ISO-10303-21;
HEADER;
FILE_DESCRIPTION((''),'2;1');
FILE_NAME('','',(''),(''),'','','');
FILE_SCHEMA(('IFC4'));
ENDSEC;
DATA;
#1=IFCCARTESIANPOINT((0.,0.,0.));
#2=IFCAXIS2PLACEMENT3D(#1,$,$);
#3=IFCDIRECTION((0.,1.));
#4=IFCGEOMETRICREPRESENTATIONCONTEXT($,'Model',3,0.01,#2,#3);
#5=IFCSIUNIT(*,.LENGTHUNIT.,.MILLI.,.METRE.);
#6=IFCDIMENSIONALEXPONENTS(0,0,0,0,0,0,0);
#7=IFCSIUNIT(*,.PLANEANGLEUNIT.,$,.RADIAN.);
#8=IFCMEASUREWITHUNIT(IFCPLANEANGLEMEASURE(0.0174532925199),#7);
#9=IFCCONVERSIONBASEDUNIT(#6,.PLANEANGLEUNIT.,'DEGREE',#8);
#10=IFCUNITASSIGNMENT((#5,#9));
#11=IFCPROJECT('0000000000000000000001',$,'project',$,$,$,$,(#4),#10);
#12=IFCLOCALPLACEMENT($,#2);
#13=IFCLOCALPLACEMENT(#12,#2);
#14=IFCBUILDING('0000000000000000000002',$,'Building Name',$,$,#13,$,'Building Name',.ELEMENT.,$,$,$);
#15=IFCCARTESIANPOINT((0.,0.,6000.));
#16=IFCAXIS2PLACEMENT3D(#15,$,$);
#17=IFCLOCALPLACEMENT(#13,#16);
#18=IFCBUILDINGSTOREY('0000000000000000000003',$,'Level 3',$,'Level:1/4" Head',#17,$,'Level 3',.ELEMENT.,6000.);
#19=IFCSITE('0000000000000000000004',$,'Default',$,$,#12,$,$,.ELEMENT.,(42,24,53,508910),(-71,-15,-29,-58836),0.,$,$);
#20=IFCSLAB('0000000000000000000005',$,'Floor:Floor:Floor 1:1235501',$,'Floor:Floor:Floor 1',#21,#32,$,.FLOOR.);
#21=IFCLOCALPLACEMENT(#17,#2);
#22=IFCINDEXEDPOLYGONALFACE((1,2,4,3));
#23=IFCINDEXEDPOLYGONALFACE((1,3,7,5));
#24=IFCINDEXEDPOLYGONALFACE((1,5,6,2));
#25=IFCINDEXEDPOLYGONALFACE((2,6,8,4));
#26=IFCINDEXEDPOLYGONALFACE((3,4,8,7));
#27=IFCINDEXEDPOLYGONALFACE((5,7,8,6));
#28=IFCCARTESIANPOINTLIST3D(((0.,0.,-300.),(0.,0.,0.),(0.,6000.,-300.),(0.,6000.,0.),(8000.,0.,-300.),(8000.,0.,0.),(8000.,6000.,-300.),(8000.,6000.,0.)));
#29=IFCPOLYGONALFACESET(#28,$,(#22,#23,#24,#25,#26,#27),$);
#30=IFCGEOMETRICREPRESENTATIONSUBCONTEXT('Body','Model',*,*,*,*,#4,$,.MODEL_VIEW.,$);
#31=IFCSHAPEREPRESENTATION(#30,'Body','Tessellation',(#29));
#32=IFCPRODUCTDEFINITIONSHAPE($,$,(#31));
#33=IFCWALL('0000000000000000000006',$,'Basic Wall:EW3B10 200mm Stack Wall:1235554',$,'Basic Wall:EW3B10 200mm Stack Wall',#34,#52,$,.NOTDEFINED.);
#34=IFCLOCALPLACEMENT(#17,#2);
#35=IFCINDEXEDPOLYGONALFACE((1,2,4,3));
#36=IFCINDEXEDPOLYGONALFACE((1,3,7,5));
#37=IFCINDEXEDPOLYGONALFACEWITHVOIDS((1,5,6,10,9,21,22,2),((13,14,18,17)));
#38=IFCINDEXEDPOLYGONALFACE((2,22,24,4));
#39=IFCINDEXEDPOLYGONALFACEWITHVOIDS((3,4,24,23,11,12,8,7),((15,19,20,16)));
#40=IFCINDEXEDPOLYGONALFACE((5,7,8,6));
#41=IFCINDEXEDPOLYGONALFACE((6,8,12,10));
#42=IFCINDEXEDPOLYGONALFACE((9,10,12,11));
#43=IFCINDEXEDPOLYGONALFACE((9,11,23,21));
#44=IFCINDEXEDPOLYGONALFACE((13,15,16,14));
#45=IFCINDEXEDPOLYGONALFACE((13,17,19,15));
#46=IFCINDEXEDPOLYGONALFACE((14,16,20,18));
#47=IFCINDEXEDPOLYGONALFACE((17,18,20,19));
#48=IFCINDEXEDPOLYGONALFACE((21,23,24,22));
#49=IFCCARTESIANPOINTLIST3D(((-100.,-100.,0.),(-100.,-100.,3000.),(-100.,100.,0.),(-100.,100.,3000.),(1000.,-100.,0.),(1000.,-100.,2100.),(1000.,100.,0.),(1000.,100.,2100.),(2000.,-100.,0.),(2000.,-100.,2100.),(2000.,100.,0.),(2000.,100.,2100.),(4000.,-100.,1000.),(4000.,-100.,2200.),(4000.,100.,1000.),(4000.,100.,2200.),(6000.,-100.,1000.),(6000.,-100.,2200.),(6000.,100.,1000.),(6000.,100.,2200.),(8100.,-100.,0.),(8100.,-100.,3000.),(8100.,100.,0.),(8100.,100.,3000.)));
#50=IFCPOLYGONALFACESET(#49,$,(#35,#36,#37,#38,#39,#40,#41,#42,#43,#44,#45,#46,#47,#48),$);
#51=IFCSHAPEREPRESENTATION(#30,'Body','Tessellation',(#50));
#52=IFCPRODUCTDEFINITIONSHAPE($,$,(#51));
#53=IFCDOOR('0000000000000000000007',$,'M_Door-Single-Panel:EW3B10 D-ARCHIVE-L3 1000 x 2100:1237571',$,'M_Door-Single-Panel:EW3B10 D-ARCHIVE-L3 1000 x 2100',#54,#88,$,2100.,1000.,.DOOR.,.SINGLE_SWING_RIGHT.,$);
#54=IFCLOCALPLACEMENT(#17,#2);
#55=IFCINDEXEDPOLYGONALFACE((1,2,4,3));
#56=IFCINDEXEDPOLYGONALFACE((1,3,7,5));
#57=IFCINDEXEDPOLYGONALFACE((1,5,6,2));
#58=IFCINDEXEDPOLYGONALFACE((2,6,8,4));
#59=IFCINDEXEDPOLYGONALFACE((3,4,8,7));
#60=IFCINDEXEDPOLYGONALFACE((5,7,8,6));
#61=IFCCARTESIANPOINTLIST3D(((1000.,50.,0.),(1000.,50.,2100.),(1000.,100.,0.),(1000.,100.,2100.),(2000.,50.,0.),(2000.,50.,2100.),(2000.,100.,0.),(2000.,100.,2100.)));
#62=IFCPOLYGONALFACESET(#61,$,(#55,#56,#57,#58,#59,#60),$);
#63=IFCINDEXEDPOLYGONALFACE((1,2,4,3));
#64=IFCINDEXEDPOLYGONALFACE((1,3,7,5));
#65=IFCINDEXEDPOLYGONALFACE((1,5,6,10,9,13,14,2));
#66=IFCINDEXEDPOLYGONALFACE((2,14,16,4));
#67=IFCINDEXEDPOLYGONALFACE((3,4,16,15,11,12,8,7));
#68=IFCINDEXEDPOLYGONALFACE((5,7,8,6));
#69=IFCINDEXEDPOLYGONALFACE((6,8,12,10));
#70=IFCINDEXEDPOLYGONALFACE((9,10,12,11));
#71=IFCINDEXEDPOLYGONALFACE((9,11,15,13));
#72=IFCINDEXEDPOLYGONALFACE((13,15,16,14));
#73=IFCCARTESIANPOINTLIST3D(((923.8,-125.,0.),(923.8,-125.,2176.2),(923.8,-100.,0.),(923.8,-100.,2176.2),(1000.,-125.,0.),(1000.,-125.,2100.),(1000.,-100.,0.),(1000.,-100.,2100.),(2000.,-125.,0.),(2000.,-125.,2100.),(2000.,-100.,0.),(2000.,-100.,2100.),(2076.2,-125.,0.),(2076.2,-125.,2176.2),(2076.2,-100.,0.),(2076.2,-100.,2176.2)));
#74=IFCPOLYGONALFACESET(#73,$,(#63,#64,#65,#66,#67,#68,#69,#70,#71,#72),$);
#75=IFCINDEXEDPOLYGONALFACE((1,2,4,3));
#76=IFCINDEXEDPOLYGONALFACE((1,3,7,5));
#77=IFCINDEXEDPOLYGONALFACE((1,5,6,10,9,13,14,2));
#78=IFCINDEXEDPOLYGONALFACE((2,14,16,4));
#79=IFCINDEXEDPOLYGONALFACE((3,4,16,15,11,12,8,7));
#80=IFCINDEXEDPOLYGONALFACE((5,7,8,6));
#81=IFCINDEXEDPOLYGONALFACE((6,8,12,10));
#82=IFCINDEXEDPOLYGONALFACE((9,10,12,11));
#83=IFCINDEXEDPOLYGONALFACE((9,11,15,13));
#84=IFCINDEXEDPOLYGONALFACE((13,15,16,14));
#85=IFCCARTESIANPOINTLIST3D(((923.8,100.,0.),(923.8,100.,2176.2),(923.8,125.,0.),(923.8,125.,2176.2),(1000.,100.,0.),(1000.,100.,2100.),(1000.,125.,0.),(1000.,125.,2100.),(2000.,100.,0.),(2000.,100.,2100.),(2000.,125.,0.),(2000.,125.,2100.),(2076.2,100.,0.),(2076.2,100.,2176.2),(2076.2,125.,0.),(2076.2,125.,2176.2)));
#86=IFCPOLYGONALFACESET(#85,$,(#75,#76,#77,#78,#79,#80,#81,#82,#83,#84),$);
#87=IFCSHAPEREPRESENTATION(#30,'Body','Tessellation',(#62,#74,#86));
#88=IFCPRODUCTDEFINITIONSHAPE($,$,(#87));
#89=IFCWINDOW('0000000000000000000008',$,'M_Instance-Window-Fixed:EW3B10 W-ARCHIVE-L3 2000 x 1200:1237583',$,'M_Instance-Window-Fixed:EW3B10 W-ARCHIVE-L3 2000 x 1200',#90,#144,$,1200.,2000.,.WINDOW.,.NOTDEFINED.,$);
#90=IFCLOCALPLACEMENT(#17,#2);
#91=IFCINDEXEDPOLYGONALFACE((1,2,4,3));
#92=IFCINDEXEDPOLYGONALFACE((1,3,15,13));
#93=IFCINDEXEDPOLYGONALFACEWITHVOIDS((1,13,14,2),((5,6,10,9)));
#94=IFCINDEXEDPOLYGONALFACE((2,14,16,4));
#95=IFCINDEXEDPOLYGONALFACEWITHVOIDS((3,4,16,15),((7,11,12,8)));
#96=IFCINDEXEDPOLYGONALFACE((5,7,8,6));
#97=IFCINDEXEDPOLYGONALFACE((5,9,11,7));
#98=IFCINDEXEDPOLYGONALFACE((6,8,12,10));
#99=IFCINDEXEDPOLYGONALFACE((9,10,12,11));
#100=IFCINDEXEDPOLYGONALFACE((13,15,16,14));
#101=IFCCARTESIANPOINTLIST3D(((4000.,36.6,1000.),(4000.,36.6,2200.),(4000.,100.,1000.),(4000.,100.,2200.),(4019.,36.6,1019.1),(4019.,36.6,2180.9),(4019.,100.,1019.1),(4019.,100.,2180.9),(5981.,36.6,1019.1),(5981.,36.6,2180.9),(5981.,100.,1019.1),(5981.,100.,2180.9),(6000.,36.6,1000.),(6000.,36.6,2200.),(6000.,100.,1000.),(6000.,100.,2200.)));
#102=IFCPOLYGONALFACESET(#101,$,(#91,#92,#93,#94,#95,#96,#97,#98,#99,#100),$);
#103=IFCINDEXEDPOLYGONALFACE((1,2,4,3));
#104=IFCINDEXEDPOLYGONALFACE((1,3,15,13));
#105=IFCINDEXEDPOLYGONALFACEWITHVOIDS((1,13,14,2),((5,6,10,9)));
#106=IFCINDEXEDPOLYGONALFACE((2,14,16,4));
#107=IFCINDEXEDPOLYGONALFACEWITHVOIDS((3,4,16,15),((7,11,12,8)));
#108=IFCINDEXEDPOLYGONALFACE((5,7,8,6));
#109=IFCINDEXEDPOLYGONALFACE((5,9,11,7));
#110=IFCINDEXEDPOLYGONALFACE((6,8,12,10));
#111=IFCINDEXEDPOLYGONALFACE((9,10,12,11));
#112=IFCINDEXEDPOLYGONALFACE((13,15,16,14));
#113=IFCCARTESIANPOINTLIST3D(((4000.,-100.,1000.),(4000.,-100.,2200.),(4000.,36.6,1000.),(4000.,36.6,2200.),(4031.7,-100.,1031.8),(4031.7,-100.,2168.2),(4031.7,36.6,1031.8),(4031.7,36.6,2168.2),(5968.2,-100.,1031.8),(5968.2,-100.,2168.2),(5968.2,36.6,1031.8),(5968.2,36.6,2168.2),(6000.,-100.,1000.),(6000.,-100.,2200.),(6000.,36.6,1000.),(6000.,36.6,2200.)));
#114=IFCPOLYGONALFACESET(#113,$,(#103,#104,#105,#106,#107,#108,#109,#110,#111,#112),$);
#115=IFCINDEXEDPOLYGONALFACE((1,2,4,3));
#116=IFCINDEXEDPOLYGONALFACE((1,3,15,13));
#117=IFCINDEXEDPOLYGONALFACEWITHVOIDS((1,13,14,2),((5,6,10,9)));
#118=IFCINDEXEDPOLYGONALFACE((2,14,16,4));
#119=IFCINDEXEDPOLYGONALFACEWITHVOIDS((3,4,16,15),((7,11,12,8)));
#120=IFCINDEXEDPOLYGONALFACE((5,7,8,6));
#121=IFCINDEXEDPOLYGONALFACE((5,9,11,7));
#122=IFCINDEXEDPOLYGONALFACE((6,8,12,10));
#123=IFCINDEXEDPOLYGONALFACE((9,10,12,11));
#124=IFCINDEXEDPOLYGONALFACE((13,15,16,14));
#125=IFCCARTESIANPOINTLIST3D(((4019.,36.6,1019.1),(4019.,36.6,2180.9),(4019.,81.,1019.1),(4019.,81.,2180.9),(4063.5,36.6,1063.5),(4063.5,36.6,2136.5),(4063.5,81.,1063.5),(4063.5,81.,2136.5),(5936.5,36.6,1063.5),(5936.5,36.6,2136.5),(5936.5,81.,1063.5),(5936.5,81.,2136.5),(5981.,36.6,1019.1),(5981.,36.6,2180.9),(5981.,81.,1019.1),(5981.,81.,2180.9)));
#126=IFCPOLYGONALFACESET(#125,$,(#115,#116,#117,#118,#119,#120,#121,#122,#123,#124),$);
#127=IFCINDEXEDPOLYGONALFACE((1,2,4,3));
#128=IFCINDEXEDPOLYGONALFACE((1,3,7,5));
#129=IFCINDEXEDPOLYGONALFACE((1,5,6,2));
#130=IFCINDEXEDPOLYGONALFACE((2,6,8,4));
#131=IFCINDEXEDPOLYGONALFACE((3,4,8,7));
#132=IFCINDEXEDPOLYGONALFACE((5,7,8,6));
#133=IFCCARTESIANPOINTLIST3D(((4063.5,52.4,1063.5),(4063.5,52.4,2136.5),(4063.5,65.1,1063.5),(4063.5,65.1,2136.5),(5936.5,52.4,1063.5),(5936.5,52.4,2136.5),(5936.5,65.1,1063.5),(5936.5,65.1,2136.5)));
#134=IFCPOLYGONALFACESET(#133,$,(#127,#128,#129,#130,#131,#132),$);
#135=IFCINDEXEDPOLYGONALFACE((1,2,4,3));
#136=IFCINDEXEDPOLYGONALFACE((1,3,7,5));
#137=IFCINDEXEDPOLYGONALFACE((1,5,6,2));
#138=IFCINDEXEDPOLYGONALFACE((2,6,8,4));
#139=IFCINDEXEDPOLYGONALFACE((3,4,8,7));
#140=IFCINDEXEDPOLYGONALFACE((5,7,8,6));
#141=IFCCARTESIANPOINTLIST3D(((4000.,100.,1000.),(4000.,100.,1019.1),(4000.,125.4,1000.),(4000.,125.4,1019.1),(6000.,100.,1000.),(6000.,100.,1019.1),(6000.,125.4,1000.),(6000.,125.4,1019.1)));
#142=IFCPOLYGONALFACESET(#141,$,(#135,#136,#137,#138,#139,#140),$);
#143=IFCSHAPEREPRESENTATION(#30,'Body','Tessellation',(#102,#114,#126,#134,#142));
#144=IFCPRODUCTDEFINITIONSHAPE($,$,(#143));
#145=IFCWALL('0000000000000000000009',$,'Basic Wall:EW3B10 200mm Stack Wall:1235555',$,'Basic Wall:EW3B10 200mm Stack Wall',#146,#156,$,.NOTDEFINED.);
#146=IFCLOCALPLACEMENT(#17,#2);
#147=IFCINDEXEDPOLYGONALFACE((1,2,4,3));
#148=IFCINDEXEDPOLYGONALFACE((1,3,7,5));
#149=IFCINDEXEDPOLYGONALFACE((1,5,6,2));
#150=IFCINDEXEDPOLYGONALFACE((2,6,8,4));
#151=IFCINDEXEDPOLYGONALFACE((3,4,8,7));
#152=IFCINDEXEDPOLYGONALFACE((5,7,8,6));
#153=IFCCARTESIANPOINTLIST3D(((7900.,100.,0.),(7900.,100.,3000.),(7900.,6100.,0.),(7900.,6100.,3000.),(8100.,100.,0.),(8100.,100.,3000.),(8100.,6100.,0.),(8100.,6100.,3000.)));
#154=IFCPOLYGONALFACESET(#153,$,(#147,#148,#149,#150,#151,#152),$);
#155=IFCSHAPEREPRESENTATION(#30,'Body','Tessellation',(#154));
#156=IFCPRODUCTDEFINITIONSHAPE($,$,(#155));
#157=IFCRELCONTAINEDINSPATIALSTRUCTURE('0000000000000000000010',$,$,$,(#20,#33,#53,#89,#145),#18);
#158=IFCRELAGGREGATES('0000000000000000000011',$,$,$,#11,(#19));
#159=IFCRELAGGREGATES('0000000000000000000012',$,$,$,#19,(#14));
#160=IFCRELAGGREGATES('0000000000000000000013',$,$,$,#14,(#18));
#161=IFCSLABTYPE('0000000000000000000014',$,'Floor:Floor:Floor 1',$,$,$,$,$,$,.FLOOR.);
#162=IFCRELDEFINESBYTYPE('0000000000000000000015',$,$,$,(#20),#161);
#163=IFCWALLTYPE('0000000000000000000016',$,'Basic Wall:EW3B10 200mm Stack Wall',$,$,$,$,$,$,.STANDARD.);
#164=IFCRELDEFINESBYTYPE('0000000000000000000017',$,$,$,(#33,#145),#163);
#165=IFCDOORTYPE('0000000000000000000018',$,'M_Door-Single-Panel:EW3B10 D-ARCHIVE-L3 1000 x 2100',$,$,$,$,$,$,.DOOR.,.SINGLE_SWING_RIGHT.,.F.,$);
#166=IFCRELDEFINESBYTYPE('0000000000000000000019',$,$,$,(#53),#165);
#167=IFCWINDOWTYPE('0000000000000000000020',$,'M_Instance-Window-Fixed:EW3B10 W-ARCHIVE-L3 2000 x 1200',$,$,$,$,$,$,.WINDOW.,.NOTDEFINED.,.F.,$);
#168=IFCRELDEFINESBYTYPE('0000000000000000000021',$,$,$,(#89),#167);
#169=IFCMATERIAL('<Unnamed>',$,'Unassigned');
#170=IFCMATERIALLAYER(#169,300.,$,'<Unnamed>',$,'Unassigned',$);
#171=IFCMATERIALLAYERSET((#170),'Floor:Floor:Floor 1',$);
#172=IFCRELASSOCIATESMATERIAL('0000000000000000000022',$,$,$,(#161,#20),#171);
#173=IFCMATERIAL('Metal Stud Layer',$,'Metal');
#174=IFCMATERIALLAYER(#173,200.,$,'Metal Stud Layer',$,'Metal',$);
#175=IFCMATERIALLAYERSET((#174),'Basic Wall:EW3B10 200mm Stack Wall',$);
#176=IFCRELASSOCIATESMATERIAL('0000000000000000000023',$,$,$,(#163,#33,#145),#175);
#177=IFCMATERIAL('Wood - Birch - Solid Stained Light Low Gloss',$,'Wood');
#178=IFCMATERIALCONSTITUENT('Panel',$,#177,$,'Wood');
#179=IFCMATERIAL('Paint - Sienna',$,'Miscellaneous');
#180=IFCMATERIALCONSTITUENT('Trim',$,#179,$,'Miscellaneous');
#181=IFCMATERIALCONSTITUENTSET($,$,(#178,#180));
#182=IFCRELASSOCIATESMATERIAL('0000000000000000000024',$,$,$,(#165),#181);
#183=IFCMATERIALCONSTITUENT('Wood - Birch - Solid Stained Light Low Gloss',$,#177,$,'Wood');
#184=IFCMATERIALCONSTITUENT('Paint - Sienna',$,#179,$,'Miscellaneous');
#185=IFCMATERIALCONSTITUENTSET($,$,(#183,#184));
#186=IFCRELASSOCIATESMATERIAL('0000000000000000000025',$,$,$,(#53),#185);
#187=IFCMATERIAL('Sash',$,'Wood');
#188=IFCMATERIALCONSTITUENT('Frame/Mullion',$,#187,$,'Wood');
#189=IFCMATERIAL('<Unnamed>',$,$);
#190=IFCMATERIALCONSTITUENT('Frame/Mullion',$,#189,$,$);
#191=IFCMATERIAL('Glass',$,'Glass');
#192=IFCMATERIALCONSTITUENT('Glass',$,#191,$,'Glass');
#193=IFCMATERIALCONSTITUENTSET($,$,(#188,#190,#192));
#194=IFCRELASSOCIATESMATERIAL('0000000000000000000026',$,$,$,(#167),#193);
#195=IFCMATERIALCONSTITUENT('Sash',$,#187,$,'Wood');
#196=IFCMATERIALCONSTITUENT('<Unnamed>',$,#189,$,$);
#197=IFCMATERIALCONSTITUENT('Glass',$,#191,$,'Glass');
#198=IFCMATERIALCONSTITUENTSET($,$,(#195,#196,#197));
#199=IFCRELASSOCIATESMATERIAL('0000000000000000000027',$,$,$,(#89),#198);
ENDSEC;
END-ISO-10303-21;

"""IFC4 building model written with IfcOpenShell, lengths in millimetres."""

from ifc_helpers import new_model, entity, si_unit, converted_unit, direction, frame, frame_2d, origin, origin_2d_with_axis, place, context, subcontext, project, spatial, polyline, rectangle, outline, extrude, source, transform, mapped, material, layer, layer_set, layer_usage, constituent, constituent_set, type_object, type_shapes, element, fill, save


model = new_model("IFC4")

# Units and contexts
model_context = context("Model", 3, precision=0.01, world=origin(), true_north=direction((0.0, 1.0)))
body_context = subcontext(model_context, "Body", "Model", "MODEL_VIEW")
ifc_project = project(units=[si_unit("LENGTHUNIT", "METRE", prefix="MILLI"), converted_unit("PLANEANGLEUNIT", "DEGREE", entity("IfcPlaneAngleMeasure", 0.0174532925199), si_unit("PLANEANGLEUNIT", "RADIAN"), dimensions=[0, 0, 0, 0, 0, 0, 0])], contexts=[model_context])

# Site, building, storey
site_placement = place(None, origin())
site = spatial("IfcSite", under=ifc_project, at=site_placement, Name="Default", CompositionType="ELEMENT", RefLatitude=(42, 24, 53, 508910), RefLongitude=(-71, -15, -29, -58836), RefElevation=0.0)
building_placement = place(site_placement, origin())
building = spatial("IfcBuilding", under=site, at=building_placement, Name="Building Name", LongName="Building Name", CompositionType="ELEMENT")
storey_placement = place(building_placement, frame((0.0, 0.0, 6000.0)))
storey = spatial("IfcBuildingStorey", under=building, at=storey_placement, Name="Level 3", ObjectType="Level:1/4\" Head", LongName="Level 3", CompositionType="ELEMENT", Elevation=6000.0)

# Slab
ifc_material_1 = material(Name="<Unnamed>", Category="Unassigned")
ifc_layer_1 = layer(ifc_material_1, 300.0, Name="<Unnamed>", Category="Unassigned")
ifc_layer_set_1 = layer_set([ifc_layer_1], Name="Floor:Floor:Floor 1")
ifc_layer_usage_1 = layer_usage(ifc_layer_set_1, "AXIS3", "POSITIVE", 0.0)
slab_type = type_object("IfcSlabType", Name="Floor:Floor:Floor 1", PredefinedType="FLOOR", material=ifc_layer_set_1)
slab_placement = place(storey_placement, origin())
element("IfcSlab", 1, at=slab_placement, inside=storey, type_object=slab_type, material=ifc_layer_usage_1, Name="Floor:Floor:Floor 1:1235501", ObjectType="Floor:Floor:Floor 1", PredefinedType="FLOOR", context=body_context, shape_type="SweptSolid", body=[
    extrude(rectangle(XDim=6000.0, YDim=8000.0, at=origin_2d_with_axis()), frame((4000.0, 3000.0, 0.0), z_axis=(0.0, 0.0, -1.0), x_axis=(0.0, 1.0, 0.0)), (0.0, 0.0, 1.0), 300.0),
])

# Wall, openings, door, window
ifc_material_2 = material(Name="Metal Stud Layer", Category="Metal")
ifc_layer_2 = layer(ifc_material_2, 200.0, Name="Metal Stud Layer", Category="Metal")
ifc_layer_set_2 = layer_set([ifc_layer_2], Name="Basic Wall:EW3B10 200mm Stack Wall")
ifc_layer_usage_2 = layer_usage(ifc_layer_set_2, "AXIS2", "NEGATIVE", 100.0)
wall_type = type_object("IfcWallType", Name="Basic Wall:EW3B10 200mm Stack Wall", PredefinedType="STANDARD", material=ifc_layer_set_2)
wall_1_placement = place(storey_placement, frame((-100.0, 0.0, 0.0)))
wall_1 = element("IfcWall", 2, at=wall_1_placement, inside=storey, type_object=wall_type, material=ifc_layer_usage_2, Name="Basic Wall:EW3B10 200mm Stack Wall:1235554", ObjectType="Basic Wall:EW3B10 200mm Stack Wall", PredefinedType="NOTDEFINED", context=body_context, shape_type="SweptSolid", body=[
    extrude(rectangle(XDim=8200.0, YDim=200.0, at=frame_2d((4100.0, 0.0), x_axis=(1.0, 0.0))), origin(), (0.0, 0.0, 1.0), 3000.0),
])
opening_1_placement = place(wall_1_placement, frame((1100.0, -100.0, 0.0)))
opening_1 = element("IfcOpeningElement", 3, at=opening_1_placement, cuts=wall_1, PredefinedType="OPENING", context=body_context, shape_type="SweptSolid", body=[
    extrude(rectangle(XDim=1000.0, YDim=2100.0, at=frame_2d((1050.0, 500.0), x_axis=(0.0, 1.0))), frame((0.0, 0.0, 0.0), z_axis=(0.0, 1.0, 0.0), x_axis=(0.0, 0.0, 1.0)), (0.0, 0.0, 1.0), 200.0),
])
opening_2_placement = place(wall_1_placement, frame((4100.0, -100.0, 1000.0)))
opening_2 = element("IfcOpeningElement", 4, at=opening_2_placement, cuts=wall_1, PredefinedType="OPENING", context=body_context, shape_type="SweptSolid", body=[
    extrude(rectangle(XDim=1200.0, YDim=2000.0, at=frame_2d((600.0, 1000.0), x_axis=(-1.0, 0.0))), frame((0.0, 0.0, 0.0), z_axis=(0.0, 1.0, 0.0), x_axis=(0.0, 0.0, 1.0)), (0.0, 0.0, 1.0), 200.0),
])
ifc_material_3 = material(Name="Wood - Birch - Solid Stained Light Low Gloss", Category="Wood")
ifc_constituent_1 = constituent(ifc_material_3, Name="Wood - Birch - Solid Stained Light Low Gloss", Category="Wood")
ifc_material_4 = material(Name="Paint - Sienna", Category="Miscellaneous")
ifc_constituent_2 = constituent(ifc_material_4, Name="Paint - Sienna", Category="Miscellaneous")
ifc_constituent_set_1 = constituent_set(constituents=[ifc_constituent_1, ifc_constituent_2])
ifc_constituent_3 = constituent(ifc_material_3, Name="Panel", Category="Wood")
ifc_constituent_4 = constituent(ifc_material_4, Name="Trim", Category="Miscellaneous")
ifc_constituent_set_2 = constituent_set(constituents=[ifc_constituent_3, ifc_constituent_4])
door_type = type_object("IfcDoorType", Name="M_Door-Single-Panel:EW3B10 D-ARCHIVE-L3 1000 x 2100", OperationType="SINGLE_SWING_RIGHT", ParameterTakesPrecedence=False, PredefinedType="DOOR", material=ifc_constituent_set_2)
shared_shape_1 = source(origin(), body_context, "Body", "SweptSolid", [
    extrude(rectangle(XDim=50.0, YDim=1000.0, at=frame_2d((0.0, 0.0), x_axis=(1.0, 0.0))), frame((500.0, 175.0, 0.0), z_axis=(0.0, 0.0, 1.0), x_axis=(0.0, 1.0, 0.0)), (0.0, 0.0, 1.0), 2100.0),
    extrude(outline(polyline([(-1107.2, -576.2), (1069.0, -576.2), (1069.0, -500.0), (-1031.0, -500.0), (-1031.0, 500.0), (1069.0, 500.0), (1069.0, 576.2), (-1107.2, 576.2), (-1107.2, -576.2)])), frame((500.0, -25.0, 1069.0), z_axis=(0.0, 1.0, 0.0), x_axis=(0.0, 0.0, -1.0)), (0.0, 0.0, 1.0), 25.0),
    extrude(outline(polyline([(-576.2, -1107.2), (576.2, -1107.2), (576.2, 1069.0), (500.0, 1069.0), (500.0, -1031.0), (-500.0, -1031.0), (-500.0, 1069.0), (-576.2, 1069.0), (-576.2, -1107.2)])), frame((500.0, 200.0, 1069.0), z_axis=(0.0, 1.0, 0.0), x_axis=(1.0, 0.0, 0.0)), (0.0, 0.0, 1.0), 25.0),
])
type_shapes(door_type, [shared_shape_1])
door_placement = place(opening_1_placement, origin())
door = element("IfcDoor", 5, at=door_placement, inside=storey, type_object=door_type, material=ifc_constituent_set_1, Name="M_Door-Single-Panel:EW3B10 D-ARCHIVE-L3 1000 x 2100:1237571", ObjectType="M_Door-Single-Panel:EW3B10 D-ARCHIVE-L3 1000 x 2100", OperationType="SINGLE_SWING_RIGHT", OverallHeight=2100.0, OverallWidth=1000.0, PredefinedType="DOOR", context=body_context, shape_type="MappedRepresentation", body=[
    mapped(shared_shape_1, transform((0.0, 0.0, 0.0), scale=1.0)),
])
fill(opening_1, door)
ifc_material_5 = material(Name="Sash", Category="Wood")
ifc_constituent_5 = constituent(ifc_material_5, Name="Sash", Category="Wood")
ifc_material_6 = material(Name="<Unnamed>")
ifc_constituent_6 = constituent(ifc_material_6, Name="<Unnamed>")
ifc_material_7 = material(Name="Glass", Category="Glass")
ifc_constituent_7 = constituent(ifc_material_7, Name="Glass", Category="Glass")
ifc_constituent_set_3 = constituent_set(constituents=[ifc_constituent_5, ifc_constituent_6, ifc_constituent_7])
ifc_constituent_8 = constituent(ifc_material_5, Name="Frame/Mullion", Category="Wood")
ifc_constituent_9 = constituent(ifc_material_6, Name="Frame/Mullion")
ifc_constituent_10 = constituent(ifc_material_7, Name="Glass", Category="Glass")
ifc_constituent_set_4 = constituent_set(constituents=[ifc_constituent_8, ifc_constituent_9, ifc_constituent_10])
window_type = type_object("IfcWindowType", Name="M_Instance-Window-Fixed:EW3B10 W-ARCHIVE-L3 2000 x 1200", ParameterTakesPrecedence=False, PartitioningType="NOTDEFINED", PredefinedType="WINDOW", material=ifc_constituent_set_4)
shared_shape_2 = source(origin(), body_context, "Body", "SweptSolid", [
    extrude(outline(polyline([(-600.0, -1000.0), (600.0, -1000.0), (600.0, 1000.0), (-600.0, 1000.0), (-600.0, -1000.0)]), holes=[polyline([(-581.0, -981.0), (-581.0, 981.0), (581.0, 981.0), (581.0, -981.0), (-581.0, -981.0)])]), frame((1000.0, 136.6, 600.0), z_axis=(0.0, 1.0, 0.0), x_axis=(0.0, 0.0, -1.0)), (0.0, 0.0, 1.0), 63.5),
    extrude(outline(polyline([(-1000.0, -600.0), (1000.0, -600.0), (1000.0, 600.0), (-1000.0, 600.0), (-1000.0, -600.0)]), holes=[polyline([(-968.2, -568.2), (-968.2, 568.2), (968.2, 568.2), (968.2, -568.2), (-968.2, -568.2)])]), frame((1000.0, 0.0, 600.0), z_axis=(0.0, 1.0, 0.0), x_axis=(1.0, 0.0, 0.0)), (0.0, 0.0, 1.0), 136.6),
    extrude(outline(polyline([(-981.0, -581.0), (981.0, -581.0), (981.0, 581.0), (-981.0, 581.0), (-981.0, -581.0)]), holes=[polyline([(-936.5, -536.5), (-936.5, 536.5), (936.5, 536.5), (936.5, -536.5), (-936.5, -536.5)])]), frame((1000.0, 136.6, 600.0), z_axis=(0.0, 1.0, 0.0), x_axis=(1.0, 0.0, 0.0)), (0.0, 0.0, 1.0), 44.5),
    extrude(rectangle(XDim=12.7, YDim=1873.0, at=frame_2d((0.0, 0.0), x_axis=(1.0, 0.0))), frame((1000.0, 158.8, 63.5), z_axis=(0.0, 0.0, 1.0), x_axis=(0.0, 1.0, 0.0)), (0.0, 0.0, 1.0), 1073.0),
    extrude(rectangle(XDim=25.4, YDim=2000.0, at=frame_2d((0.0, 0.0), x_axis=(1.0, 0.0))), frame((1000.0, 212.7, 0.0), z_axis=(0.0, 0.0, 1.0), x_axis=(0.0, -1.0, 0.0)), (0.0, 0.0, 1.0), 19.1),
])
type_shapes(window_type, [shared_shape_2])
window_placement = place(opening_2_placement, origin())
window = element("IfcWindow", 6, at=window_placement, inside=storey, type_object=window_type, material=ifc_constituent_set_3, Name="M_Instance-Window-Fixed:EW3B10 W-ARCHIVE-L3 2000 x 1200:1237583", ObjectType="M_Instance-Window-Fixed:EW3B10 W-ARCHIVE-L3 2000 x 1200", OverallHeight=1200.0, OverallWidth=2000.0, PartitioningType="NOTDEFINED", PredefinedType="WINDOW", context=body_context, shape_type="MappedRepresentation", body=[
    mapped(shared_shape_2, transform((0.0, 0.0, 0.0), scale=1.0)),
])
fill(opening_2, window)

# Wall
ifc_layer_usage_3 = layer_usage(ifc_layer_set_2, "AXIS2", "NEGATIVE", 100.0)
wall_2_placement = place(storey_placement, frame((8000.0, 100.0, 0.0), z_axis=(0.0, 0.0, 1.0), x_axis=(0.0, 1.0, 0.0)))
element("IfcWall", 7, at=wall_2_placement, inside=storey, type_object=wall_type, material=ifc_layer_usage_3, Name="Basic Wall:EW3B10 200mm Stack Wall:1235555", ObjectType="Basic Wall:EW3B10 200mm Stack Wall", PredefinedType="NOTDEFINED", context=body_context, shape_type="SweptSolid", body=[
    extrude(rectangle(XDim=6000.0, YDim=200.0, at=frame_2d((3000.0, 0.0), x_axis=(-1.0, 0.0))), origin(), (0.0, 0.0, 1.0), 3000.0),
])

save(model, "model.ifc")
